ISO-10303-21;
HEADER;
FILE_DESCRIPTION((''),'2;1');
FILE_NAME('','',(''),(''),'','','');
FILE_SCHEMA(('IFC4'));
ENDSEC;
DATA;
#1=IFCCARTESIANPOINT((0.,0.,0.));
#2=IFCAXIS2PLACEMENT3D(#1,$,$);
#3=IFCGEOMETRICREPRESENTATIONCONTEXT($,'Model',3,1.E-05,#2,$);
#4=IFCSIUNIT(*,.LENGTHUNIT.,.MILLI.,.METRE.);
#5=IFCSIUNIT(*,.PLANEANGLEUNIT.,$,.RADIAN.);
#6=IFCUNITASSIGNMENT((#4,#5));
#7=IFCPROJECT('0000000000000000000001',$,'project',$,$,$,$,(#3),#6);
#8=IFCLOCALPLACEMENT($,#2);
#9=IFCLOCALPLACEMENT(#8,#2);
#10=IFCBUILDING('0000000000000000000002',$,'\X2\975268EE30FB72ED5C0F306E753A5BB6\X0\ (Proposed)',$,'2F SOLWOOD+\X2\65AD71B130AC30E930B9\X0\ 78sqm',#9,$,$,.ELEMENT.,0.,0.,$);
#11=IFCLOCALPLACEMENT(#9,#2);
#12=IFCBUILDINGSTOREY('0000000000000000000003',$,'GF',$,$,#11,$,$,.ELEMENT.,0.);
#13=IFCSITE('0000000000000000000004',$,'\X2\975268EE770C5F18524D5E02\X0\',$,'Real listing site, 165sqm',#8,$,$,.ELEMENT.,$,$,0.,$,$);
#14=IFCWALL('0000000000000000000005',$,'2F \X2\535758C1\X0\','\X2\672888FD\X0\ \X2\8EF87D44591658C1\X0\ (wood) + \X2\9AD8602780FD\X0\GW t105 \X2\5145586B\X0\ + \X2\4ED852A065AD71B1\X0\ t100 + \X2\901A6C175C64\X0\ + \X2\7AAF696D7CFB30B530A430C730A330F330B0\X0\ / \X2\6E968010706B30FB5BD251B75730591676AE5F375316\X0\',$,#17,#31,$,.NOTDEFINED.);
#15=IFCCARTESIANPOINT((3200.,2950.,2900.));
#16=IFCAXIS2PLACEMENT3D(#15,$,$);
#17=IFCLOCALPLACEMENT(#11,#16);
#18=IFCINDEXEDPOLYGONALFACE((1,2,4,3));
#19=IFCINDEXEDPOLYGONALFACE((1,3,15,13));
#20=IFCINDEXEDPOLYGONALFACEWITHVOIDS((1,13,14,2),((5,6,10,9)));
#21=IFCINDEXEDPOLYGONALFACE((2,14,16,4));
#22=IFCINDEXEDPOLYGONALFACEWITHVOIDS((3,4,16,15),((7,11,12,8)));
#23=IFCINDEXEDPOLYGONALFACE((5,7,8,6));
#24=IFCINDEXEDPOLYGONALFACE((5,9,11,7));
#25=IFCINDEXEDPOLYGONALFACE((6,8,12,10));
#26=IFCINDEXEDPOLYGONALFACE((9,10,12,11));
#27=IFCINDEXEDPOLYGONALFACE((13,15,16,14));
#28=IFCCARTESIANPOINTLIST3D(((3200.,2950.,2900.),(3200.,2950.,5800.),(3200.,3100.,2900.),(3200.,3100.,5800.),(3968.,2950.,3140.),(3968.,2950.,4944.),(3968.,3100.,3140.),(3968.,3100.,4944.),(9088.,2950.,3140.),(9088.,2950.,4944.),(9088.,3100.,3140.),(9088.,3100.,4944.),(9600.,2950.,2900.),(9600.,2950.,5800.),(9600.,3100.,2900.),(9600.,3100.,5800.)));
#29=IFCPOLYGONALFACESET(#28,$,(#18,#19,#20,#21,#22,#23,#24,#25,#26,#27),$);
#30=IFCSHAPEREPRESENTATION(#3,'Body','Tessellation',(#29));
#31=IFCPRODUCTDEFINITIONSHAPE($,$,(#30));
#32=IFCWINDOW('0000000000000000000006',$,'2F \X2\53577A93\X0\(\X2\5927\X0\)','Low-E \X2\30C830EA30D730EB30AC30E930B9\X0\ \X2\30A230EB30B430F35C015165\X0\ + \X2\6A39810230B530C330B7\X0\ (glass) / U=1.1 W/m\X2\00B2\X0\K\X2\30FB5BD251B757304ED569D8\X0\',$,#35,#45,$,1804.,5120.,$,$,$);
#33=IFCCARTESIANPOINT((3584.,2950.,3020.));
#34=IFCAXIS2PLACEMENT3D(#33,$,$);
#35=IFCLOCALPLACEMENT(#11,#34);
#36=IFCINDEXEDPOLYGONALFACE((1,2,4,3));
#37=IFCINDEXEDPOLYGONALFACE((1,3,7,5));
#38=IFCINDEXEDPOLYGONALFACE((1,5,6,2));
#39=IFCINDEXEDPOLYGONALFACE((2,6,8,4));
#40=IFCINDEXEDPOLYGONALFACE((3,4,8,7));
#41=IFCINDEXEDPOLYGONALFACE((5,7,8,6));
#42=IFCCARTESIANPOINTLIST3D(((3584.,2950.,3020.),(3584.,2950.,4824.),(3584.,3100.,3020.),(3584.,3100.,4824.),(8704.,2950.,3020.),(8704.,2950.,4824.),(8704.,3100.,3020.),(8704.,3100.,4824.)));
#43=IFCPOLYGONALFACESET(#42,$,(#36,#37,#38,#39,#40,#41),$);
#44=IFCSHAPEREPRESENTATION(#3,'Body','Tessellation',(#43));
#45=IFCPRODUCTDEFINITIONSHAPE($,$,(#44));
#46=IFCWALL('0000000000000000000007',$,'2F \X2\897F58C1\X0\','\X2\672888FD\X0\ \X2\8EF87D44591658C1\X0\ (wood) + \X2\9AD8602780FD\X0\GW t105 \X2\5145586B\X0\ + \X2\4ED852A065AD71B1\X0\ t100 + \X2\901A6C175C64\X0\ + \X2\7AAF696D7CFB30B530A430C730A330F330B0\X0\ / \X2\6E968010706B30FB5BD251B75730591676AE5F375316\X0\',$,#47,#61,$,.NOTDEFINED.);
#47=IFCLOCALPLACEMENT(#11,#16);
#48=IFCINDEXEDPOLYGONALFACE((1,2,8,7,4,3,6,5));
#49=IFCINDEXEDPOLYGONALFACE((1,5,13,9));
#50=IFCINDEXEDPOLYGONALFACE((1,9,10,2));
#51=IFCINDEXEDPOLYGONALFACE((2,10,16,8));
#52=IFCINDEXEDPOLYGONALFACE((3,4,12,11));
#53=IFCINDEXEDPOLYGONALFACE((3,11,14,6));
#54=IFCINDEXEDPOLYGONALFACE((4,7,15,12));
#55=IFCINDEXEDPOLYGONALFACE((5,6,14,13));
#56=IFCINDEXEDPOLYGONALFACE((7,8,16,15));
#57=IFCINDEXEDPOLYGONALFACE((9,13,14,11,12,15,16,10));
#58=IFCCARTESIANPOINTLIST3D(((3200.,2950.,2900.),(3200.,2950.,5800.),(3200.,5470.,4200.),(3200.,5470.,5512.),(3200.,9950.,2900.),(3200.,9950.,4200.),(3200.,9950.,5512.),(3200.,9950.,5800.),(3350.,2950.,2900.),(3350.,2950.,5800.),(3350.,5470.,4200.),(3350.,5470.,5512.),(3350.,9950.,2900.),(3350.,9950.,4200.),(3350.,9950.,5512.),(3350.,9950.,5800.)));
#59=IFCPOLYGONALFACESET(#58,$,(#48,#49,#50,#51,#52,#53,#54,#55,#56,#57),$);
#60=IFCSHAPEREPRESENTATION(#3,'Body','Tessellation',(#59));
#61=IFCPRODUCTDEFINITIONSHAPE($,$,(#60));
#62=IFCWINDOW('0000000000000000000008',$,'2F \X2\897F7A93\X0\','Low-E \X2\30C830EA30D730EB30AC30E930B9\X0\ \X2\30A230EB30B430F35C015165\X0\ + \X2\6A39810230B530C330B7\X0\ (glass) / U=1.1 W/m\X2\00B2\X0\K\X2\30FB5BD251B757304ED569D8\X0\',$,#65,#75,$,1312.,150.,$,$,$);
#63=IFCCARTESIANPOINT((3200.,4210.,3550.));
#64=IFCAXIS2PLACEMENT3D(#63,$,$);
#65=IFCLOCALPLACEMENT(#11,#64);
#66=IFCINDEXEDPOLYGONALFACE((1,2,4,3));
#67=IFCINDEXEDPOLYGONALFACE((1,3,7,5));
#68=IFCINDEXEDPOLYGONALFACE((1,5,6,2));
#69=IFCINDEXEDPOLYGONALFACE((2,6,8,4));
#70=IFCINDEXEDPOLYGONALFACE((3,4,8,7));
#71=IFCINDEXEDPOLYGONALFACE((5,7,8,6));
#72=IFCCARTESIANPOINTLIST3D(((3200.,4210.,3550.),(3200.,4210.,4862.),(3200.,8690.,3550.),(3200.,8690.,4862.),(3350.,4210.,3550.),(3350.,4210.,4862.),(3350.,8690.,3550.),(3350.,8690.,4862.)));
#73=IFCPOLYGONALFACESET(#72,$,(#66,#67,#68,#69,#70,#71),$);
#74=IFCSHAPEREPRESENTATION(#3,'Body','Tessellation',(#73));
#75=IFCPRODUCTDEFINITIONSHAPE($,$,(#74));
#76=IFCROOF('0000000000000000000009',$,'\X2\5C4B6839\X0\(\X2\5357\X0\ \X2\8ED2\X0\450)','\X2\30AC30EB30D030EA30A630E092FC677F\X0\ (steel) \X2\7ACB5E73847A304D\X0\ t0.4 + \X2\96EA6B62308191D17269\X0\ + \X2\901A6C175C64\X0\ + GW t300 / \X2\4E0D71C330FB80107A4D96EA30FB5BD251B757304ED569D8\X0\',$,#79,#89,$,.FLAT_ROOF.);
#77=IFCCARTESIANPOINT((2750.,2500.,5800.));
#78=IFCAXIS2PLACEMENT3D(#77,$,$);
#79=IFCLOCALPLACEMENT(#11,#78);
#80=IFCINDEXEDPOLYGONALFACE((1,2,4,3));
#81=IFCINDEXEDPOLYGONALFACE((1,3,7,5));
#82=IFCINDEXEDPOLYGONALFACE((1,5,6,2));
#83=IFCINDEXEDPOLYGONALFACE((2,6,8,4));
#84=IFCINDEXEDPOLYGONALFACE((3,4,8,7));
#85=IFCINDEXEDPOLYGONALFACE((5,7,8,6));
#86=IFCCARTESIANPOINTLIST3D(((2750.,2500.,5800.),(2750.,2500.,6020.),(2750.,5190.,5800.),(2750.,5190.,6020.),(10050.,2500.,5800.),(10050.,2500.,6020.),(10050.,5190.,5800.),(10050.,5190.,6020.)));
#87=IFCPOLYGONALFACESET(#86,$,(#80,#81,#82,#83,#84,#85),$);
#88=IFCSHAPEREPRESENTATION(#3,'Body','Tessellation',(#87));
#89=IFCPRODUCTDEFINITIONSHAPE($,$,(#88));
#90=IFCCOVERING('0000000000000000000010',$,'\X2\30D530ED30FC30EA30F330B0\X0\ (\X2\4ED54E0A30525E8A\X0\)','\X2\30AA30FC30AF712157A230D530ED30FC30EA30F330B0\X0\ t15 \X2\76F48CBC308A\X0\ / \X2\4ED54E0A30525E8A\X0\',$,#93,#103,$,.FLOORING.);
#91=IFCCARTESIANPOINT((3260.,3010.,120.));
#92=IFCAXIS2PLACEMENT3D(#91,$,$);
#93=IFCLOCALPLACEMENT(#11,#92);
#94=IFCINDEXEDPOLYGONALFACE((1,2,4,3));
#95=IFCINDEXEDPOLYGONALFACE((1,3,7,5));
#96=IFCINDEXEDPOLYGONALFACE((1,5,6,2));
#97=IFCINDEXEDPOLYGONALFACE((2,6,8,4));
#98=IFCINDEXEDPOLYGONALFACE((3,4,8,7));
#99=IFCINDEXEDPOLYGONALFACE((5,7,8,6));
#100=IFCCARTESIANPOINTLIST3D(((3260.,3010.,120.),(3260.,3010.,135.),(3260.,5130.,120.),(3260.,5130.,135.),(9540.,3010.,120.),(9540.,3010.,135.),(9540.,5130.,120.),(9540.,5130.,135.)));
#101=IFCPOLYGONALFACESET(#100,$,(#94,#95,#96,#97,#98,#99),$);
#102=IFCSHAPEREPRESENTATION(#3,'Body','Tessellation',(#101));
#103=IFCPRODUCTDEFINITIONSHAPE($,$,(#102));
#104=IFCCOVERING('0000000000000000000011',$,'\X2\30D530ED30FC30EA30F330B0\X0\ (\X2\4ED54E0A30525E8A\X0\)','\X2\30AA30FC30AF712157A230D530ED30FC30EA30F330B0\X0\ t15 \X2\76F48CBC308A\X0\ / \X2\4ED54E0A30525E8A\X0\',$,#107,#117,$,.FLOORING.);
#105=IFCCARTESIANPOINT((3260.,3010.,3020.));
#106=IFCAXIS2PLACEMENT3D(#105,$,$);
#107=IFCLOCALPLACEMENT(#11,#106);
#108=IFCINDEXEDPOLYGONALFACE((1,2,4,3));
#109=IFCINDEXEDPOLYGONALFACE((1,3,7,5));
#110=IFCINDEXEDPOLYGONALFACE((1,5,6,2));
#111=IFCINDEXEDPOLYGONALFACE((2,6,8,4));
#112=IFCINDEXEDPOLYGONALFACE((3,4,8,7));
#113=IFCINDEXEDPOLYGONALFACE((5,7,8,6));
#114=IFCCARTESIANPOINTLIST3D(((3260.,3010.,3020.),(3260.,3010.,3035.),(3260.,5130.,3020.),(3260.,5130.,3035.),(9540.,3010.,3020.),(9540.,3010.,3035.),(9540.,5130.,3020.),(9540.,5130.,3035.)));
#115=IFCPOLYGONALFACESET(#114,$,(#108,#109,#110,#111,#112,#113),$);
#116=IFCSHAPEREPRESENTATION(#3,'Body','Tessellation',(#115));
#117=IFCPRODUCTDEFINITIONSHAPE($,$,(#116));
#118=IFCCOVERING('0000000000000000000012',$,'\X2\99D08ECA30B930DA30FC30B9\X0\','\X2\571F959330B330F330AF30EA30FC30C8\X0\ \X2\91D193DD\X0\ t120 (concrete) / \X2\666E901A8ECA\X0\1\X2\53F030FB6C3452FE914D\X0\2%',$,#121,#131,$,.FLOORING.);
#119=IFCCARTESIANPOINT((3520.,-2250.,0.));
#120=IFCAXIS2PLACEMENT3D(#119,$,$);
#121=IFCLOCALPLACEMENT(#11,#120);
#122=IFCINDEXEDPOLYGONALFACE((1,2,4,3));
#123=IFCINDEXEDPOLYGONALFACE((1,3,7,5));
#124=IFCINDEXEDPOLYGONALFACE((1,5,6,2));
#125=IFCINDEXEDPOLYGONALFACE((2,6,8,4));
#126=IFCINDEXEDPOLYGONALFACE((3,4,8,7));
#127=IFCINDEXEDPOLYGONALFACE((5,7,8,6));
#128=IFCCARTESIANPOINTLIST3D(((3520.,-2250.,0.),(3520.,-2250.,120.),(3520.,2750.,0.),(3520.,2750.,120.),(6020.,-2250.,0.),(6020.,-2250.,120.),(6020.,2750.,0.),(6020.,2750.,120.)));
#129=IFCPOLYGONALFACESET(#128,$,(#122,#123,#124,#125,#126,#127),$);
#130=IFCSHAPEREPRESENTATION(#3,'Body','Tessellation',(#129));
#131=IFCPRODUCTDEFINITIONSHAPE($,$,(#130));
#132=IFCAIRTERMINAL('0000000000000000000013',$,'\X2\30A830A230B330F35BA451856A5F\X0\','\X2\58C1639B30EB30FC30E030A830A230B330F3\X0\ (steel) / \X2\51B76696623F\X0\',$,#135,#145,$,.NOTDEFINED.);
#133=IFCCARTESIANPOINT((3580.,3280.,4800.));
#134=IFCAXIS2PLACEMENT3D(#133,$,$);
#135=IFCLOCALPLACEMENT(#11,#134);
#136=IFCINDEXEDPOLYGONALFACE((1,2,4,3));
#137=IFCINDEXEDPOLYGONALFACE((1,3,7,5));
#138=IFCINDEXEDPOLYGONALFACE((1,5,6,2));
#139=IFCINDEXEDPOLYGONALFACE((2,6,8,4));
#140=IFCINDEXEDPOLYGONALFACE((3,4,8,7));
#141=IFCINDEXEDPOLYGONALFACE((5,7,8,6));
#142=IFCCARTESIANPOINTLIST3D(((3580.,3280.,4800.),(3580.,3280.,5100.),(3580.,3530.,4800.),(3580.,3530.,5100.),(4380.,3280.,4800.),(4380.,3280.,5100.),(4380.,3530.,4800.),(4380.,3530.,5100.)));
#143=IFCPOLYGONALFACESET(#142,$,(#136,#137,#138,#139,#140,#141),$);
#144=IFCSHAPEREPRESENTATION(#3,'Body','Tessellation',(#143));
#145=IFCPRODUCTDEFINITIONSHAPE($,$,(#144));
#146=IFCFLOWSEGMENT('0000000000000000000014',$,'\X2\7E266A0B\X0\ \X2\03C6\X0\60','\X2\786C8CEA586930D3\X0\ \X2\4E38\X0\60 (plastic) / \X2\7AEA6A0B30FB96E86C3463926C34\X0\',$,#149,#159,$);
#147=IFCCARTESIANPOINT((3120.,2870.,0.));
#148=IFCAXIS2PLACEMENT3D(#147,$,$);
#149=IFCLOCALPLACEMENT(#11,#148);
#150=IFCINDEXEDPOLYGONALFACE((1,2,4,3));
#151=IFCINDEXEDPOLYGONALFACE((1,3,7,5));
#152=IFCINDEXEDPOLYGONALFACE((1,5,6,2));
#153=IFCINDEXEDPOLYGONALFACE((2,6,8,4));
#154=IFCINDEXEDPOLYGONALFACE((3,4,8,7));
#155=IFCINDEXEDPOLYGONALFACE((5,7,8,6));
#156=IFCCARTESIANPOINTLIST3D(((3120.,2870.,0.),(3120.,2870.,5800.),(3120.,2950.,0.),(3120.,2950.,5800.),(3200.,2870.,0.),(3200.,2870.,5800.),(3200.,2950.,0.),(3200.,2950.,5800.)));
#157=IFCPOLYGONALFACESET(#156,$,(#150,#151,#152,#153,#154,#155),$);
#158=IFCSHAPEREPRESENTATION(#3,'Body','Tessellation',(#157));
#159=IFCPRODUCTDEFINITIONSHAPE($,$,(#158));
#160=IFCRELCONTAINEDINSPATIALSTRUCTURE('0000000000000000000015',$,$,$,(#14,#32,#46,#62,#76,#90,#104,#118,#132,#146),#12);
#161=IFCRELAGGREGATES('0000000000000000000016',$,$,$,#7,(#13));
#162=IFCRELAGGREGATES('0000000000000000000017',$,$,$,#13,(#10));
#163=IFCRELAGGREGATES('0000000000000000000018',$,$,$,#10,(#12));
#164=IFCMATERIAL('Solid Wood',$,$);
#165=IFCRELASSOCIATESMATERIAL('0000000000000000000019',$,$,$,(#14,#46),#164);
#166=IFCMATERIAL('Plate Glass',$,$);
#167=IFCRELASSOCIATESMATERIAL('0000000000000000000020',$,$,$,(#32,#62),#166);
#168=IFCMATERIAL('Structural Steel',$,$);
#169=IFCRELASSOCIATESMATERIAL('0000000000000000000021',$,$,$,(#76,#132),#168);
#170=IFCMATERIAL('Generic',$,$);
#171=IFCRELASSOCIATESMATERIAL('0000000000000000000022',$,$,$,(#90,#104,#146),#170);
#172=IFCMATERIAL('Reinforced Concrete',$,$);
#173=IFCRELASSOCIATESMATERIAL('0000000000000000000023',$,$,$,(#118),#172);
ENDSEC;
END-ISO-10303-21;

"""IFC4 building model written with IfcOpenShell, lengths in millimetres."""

from ifc_helpers import new_model, si_unit, frame, frame_2d, origin, place, context, project, spatial, rectangle, extrude, material, element, fill, save


model = new_model("IFC4")

# Units and contexts
model_context = context("Model", 3, precision=1e-05, world=origin())
ifc_project = project(units=[si_unit("LENGTHUNIT", "METRE", prefix="MILLI"), si_unit("PLANEANGLEUNIT", "RADIAN")], contexts=[model_context])

# Site, building, storey
site_placement = place(None, origin())
site = spatial("IfcSite", under=ifc_project, at=site_placement, Name="青森県弘前市", ObjectType="Real listing site, 165sqm", CompositionType="ELEMENT", RefElevation=0.0)
building_placement = place(site_placement, origin())
building = spatial("IfcBuilding", under=site, at=building_placement, Name="青森・狭小の町家 (Proposed)", ObjectType="2F SOLWOOD+断熱ガラス 78sqm", CompositionType="ELEMENT", ElevationOfRefHeight=0.0, ElevationOfTerrain=0.0)
storey_placement = place(building_placement, origin())
storey = spatial("IfcBuildingStorey", under=building, at=storey_placement, Name="GF", CompositionType="ELEMENT", Elevation=0.0)

# Shared definitions
ifc_material_1 = material(Name="Solid Wood")

# Shared definitions
ifc_material_2 = material(Name="Reinforced Concrete")

# Shared definitions
ifc_material_3 = material(Name="Plate Glass")

# Walls, openings, windows
wall_1_placement = place(storey_placement, frame((3200.0, 2950.0, 2900.0)))
wall_1 = element("IfcWall", 1, at=wall_1_placement, inside=storey, material=ifc_material_1, Name="2F 南壁", Description="木製 軸組外壁 (wood) + 高性能GW t105 充填 + 付加断熱 t100 + 通気層 + 窯業系サイディング / 準耐火・寒冷地外皮強化", PredefinedType="NOTDEFINED", context=model_context, shape_type="SweptSolid", body=[
    extrude(rectangle(XDim=6400.0, YDim=150.0, at=frame_2d((3200.0, 75.0))), frame((3200.0, 2950.0, 2900.0)), (0.0, 0.0, 1.0), 2900.0),
])
opening_1_placement = place(storey_placement, frame((3584.0, 2950.0, 3020.0)))
opening_1 = element("IfcOpeningElement", 2, at=opening_1_placement, cuts=wall_1, PredefinedType="NOTDEFINED", context=model_context, shape_type="SweptSolid", body=[
    extrude(rectangle(XDim=5120.0, YDim=150.0, at=frame_2d((2560.0, 75.0))), frame((3584.0, 2950.0, 3020.0)), (0.0, 0.0, 1.0), 1804.0),
])
window_1_placement = place(storey_placement, frame((3584.0, 2950.0, 3020.0)))
window_1 = element("IfcWindow", 3, at=window_1_placement, inside=storey, material=ifc_material_3, Name="2F 南窓(大)", Description="Low-E トリプルガラス アルゴン封入 + 樹脂サッシ (glass) / U=1.1 W/m²K・寒冷地仕様", OverallHeight=1804.0, OverallWidth=5120.0, context=model_context, shape_type="SweptSolid", body=[
    extrude(rectangle(XDim=5120.0, YDim=150.0, at=frame_2d((2560.0, 75.0))), frame((3584.0, 2950.0, 3020.0)), (0.0, 0.0, 1.0), 1804.0),
])
fill(opening_1, window_1)
wall_2_placement = place(storey_placement, frame((3200.0, 2950.0, 2900.0)))
wall_2 = element("IfcWall", 4, at=wall_2_placement, inside=storey, material=ifc_material_1, Name="2F 西壁", Description="木製 軸組外壁 (wood) + 高性能GW t105 充填 + 付加断熱 t100 + 通気層 + 窯業系サイディング / 準耐火・寒冷地外皮強化", PredefinedType="NOTDEFINED", context=model_context, shape_type="SweptSolid", body=[
    extrude(rectangle(XDim=150.0, YDim=7000.0, at=frame_2d((75.0, 3500.0))), frame((3200.0, 2950.0, 2900.0)), (0.0, 0.0, 1.0), 2900.0),
])
opening_2_placement = place(storey_placement, frame((3200.0, 4210.0, 3550.0)))
opening_2 = element("IfcOpeningElement", 5, at=opening_2_placement, cuts=wall_2, PredefinedType="NOTDEFINED", context=model_context, shape_type="SweptSolid", body=[
    extrude(rectangle(XDim=150.0, YDim=4480.0, at=frame_2d((75.0, 2240.0))), frame((3200.0, 4210.0, 3550.0)), (0.0, 0.0, 1.0), 1312.0),
])
window_2_placement = place(storey_placement, frame((3200.0, 4210.0, 3550.0)))
window_2 = element("IfcWindow", 6, at=window_2_placement, inside=storey, material=ifc_material_3, Name="2F 西窓", Description="Low-E トリプルガラス アルゴン封入 + 樹脂サッシ (glass) / U=1.1 W/m²K・寒冷地仕様", OverallHeight=1312.0, OverallWidth=150.0, context=model_context, shape_type="SweptSolid", body=[
    extrude(rectangle(XDim=150.0, YDim=4480.0, at=frame_2d((75.0, 2240.0))), frame((3200.0, 4210.0, 3550.0)), (0.0, 0.0, 1.0), 1312.0),
])
fill(opening_2, window_2)

# Roof
ifc_material_4 = material(Name="Structural Steel")
for number, where, name in (
    (7, (2750.0, 2500.0, 5800.0), "屋根(南 軒450)"),
):
    element("IfcRoof", number, at=place(storey_placement, frame(where)), inside=storey, material=ifc_material_4, Name=name, Description="ガルバリウム鋼板 (steel) 立平葺き t0.4 + 雪止め金物 + 通気層 + GW t300 / 不燃・耐積雪・寒冷地仕様", PredefinedType="FLAT_ROOF", context=model_context, shape_type="SweptSolid", body=[
        extrude(rectangle(XDim=7300.0, YDim=2690.0, at=frame_2d((3650.0, 1345.0))), frame((2750.0, 2500.0, 5800.0)), (0.0, 0.0, 1.0), 220.0),
    ])

# Coverings
ifc_material_5 = material(Name="Generic")
covering_1_placement = place(storey_placement, frame((3260.0, 3010.0, 120.0)))
element("IfcCovering", 8, at=covering_1_placement, inside=storey, material=ifc_material_5, Name="フローリング (仕上げ床)", Description="オーク無垢フローリング t15 直貼り / 仕上げ床", PredefinedType="FLOORING", context=model_context, shape_type="SweptSolid", body=[
    extrude(rectangle(XDim=6280.0, YDim=2120.0, at=frame_2d((3140.0, 1060.0))), frame((3260.0, 3010.0, 120.0)), (0.0, 0.0, 1.0), 15.0),
])
covering_2_placement = place(storey_placement, frame((3260.0, 3010.0, 3020.0)))
element("IfcCovering", 9, at=covering_2_placement, inside=storey, material=ifc_material_5, Name="フローリング (仕上げ床)", Description="オーク無垢フローリング t15 直貼り / 仕上げ床", PredefinedType="FLOORING", context=model_context, shape_type="SweptSolid", body=[
    extrude(rectangle(XDim=6280.0, YDim=2120.0, at=frame_2d((3140.0, 1060.0))), frame((3260.0, 3010.0, 3020.0)), (0.0, 0.0, 1.0), 15.0),
])
covering_3_placement = place(storey_placement, frame((3520.0, -2250.0, 0.0)))
element("IfcCovering", 10, at=covering_3_placement, inside=storey, material=ifc_material_2, Name="駐車スペース", Description="土間コンクリート 金鏝 t120 (concrete) / 普通車1台・水勾配2%", PredefinedType="FLOORING", context=model_context, shape_type="SweptSolid", body=[
    extrude(rectangle(XDim=2500.0, YDim=5000.0, at=frame_2d((1250.0, 2500.0))), frame((3520.0, -2250.0, 0.0)), (0.0, 0.0, 1.0), 120.0),
])

# Air terminal
air_terminal_placement = place(storey_placement, frame((3580.0, 3280.0, 4800.0)))
element("IfcAirTerminal", 11, at=air_terminal_placement, inside=storey, material=ifc_material_4, Name="エアコン室内機", Description="壁掛ルームエアコン (steel) / 冷暖房", PredefinedType="NOTDEFINED", context=model_context, shape_type="SweptSolid", body=[
    extrude(rectangle(XDim=800.0, YDim=250.0, at=frame_2d((400.0, 125.0))), frame((3580.0, 3280.0, 4800.0)), (0.0, 0.0, 1.0), 300.0),
])

# Flow segment
flow_segment_1_placement = place(storey_placement, frame((3120.0, 2870.0, 0.0)))
element("IfcFlowSegment", 12, at=flow_segment_1_placement, inside=storey, material=ifc_material_5, Name="縦樋 φ60", Description="硬質塩ビ 丸60 (plastic) / 竪樋・雨水排水", context=model_context, shape_type="SweptSolid", body=[
    extrude(rectangle(XDim=80.0, YDim=80.0, at=frame_2d((40.0, 40.0))), frame((3120.0, 2870.0, 0.0)), (0.0, 0.0, 1.0), 5800.0),
])

save(model, "model.ifc")
